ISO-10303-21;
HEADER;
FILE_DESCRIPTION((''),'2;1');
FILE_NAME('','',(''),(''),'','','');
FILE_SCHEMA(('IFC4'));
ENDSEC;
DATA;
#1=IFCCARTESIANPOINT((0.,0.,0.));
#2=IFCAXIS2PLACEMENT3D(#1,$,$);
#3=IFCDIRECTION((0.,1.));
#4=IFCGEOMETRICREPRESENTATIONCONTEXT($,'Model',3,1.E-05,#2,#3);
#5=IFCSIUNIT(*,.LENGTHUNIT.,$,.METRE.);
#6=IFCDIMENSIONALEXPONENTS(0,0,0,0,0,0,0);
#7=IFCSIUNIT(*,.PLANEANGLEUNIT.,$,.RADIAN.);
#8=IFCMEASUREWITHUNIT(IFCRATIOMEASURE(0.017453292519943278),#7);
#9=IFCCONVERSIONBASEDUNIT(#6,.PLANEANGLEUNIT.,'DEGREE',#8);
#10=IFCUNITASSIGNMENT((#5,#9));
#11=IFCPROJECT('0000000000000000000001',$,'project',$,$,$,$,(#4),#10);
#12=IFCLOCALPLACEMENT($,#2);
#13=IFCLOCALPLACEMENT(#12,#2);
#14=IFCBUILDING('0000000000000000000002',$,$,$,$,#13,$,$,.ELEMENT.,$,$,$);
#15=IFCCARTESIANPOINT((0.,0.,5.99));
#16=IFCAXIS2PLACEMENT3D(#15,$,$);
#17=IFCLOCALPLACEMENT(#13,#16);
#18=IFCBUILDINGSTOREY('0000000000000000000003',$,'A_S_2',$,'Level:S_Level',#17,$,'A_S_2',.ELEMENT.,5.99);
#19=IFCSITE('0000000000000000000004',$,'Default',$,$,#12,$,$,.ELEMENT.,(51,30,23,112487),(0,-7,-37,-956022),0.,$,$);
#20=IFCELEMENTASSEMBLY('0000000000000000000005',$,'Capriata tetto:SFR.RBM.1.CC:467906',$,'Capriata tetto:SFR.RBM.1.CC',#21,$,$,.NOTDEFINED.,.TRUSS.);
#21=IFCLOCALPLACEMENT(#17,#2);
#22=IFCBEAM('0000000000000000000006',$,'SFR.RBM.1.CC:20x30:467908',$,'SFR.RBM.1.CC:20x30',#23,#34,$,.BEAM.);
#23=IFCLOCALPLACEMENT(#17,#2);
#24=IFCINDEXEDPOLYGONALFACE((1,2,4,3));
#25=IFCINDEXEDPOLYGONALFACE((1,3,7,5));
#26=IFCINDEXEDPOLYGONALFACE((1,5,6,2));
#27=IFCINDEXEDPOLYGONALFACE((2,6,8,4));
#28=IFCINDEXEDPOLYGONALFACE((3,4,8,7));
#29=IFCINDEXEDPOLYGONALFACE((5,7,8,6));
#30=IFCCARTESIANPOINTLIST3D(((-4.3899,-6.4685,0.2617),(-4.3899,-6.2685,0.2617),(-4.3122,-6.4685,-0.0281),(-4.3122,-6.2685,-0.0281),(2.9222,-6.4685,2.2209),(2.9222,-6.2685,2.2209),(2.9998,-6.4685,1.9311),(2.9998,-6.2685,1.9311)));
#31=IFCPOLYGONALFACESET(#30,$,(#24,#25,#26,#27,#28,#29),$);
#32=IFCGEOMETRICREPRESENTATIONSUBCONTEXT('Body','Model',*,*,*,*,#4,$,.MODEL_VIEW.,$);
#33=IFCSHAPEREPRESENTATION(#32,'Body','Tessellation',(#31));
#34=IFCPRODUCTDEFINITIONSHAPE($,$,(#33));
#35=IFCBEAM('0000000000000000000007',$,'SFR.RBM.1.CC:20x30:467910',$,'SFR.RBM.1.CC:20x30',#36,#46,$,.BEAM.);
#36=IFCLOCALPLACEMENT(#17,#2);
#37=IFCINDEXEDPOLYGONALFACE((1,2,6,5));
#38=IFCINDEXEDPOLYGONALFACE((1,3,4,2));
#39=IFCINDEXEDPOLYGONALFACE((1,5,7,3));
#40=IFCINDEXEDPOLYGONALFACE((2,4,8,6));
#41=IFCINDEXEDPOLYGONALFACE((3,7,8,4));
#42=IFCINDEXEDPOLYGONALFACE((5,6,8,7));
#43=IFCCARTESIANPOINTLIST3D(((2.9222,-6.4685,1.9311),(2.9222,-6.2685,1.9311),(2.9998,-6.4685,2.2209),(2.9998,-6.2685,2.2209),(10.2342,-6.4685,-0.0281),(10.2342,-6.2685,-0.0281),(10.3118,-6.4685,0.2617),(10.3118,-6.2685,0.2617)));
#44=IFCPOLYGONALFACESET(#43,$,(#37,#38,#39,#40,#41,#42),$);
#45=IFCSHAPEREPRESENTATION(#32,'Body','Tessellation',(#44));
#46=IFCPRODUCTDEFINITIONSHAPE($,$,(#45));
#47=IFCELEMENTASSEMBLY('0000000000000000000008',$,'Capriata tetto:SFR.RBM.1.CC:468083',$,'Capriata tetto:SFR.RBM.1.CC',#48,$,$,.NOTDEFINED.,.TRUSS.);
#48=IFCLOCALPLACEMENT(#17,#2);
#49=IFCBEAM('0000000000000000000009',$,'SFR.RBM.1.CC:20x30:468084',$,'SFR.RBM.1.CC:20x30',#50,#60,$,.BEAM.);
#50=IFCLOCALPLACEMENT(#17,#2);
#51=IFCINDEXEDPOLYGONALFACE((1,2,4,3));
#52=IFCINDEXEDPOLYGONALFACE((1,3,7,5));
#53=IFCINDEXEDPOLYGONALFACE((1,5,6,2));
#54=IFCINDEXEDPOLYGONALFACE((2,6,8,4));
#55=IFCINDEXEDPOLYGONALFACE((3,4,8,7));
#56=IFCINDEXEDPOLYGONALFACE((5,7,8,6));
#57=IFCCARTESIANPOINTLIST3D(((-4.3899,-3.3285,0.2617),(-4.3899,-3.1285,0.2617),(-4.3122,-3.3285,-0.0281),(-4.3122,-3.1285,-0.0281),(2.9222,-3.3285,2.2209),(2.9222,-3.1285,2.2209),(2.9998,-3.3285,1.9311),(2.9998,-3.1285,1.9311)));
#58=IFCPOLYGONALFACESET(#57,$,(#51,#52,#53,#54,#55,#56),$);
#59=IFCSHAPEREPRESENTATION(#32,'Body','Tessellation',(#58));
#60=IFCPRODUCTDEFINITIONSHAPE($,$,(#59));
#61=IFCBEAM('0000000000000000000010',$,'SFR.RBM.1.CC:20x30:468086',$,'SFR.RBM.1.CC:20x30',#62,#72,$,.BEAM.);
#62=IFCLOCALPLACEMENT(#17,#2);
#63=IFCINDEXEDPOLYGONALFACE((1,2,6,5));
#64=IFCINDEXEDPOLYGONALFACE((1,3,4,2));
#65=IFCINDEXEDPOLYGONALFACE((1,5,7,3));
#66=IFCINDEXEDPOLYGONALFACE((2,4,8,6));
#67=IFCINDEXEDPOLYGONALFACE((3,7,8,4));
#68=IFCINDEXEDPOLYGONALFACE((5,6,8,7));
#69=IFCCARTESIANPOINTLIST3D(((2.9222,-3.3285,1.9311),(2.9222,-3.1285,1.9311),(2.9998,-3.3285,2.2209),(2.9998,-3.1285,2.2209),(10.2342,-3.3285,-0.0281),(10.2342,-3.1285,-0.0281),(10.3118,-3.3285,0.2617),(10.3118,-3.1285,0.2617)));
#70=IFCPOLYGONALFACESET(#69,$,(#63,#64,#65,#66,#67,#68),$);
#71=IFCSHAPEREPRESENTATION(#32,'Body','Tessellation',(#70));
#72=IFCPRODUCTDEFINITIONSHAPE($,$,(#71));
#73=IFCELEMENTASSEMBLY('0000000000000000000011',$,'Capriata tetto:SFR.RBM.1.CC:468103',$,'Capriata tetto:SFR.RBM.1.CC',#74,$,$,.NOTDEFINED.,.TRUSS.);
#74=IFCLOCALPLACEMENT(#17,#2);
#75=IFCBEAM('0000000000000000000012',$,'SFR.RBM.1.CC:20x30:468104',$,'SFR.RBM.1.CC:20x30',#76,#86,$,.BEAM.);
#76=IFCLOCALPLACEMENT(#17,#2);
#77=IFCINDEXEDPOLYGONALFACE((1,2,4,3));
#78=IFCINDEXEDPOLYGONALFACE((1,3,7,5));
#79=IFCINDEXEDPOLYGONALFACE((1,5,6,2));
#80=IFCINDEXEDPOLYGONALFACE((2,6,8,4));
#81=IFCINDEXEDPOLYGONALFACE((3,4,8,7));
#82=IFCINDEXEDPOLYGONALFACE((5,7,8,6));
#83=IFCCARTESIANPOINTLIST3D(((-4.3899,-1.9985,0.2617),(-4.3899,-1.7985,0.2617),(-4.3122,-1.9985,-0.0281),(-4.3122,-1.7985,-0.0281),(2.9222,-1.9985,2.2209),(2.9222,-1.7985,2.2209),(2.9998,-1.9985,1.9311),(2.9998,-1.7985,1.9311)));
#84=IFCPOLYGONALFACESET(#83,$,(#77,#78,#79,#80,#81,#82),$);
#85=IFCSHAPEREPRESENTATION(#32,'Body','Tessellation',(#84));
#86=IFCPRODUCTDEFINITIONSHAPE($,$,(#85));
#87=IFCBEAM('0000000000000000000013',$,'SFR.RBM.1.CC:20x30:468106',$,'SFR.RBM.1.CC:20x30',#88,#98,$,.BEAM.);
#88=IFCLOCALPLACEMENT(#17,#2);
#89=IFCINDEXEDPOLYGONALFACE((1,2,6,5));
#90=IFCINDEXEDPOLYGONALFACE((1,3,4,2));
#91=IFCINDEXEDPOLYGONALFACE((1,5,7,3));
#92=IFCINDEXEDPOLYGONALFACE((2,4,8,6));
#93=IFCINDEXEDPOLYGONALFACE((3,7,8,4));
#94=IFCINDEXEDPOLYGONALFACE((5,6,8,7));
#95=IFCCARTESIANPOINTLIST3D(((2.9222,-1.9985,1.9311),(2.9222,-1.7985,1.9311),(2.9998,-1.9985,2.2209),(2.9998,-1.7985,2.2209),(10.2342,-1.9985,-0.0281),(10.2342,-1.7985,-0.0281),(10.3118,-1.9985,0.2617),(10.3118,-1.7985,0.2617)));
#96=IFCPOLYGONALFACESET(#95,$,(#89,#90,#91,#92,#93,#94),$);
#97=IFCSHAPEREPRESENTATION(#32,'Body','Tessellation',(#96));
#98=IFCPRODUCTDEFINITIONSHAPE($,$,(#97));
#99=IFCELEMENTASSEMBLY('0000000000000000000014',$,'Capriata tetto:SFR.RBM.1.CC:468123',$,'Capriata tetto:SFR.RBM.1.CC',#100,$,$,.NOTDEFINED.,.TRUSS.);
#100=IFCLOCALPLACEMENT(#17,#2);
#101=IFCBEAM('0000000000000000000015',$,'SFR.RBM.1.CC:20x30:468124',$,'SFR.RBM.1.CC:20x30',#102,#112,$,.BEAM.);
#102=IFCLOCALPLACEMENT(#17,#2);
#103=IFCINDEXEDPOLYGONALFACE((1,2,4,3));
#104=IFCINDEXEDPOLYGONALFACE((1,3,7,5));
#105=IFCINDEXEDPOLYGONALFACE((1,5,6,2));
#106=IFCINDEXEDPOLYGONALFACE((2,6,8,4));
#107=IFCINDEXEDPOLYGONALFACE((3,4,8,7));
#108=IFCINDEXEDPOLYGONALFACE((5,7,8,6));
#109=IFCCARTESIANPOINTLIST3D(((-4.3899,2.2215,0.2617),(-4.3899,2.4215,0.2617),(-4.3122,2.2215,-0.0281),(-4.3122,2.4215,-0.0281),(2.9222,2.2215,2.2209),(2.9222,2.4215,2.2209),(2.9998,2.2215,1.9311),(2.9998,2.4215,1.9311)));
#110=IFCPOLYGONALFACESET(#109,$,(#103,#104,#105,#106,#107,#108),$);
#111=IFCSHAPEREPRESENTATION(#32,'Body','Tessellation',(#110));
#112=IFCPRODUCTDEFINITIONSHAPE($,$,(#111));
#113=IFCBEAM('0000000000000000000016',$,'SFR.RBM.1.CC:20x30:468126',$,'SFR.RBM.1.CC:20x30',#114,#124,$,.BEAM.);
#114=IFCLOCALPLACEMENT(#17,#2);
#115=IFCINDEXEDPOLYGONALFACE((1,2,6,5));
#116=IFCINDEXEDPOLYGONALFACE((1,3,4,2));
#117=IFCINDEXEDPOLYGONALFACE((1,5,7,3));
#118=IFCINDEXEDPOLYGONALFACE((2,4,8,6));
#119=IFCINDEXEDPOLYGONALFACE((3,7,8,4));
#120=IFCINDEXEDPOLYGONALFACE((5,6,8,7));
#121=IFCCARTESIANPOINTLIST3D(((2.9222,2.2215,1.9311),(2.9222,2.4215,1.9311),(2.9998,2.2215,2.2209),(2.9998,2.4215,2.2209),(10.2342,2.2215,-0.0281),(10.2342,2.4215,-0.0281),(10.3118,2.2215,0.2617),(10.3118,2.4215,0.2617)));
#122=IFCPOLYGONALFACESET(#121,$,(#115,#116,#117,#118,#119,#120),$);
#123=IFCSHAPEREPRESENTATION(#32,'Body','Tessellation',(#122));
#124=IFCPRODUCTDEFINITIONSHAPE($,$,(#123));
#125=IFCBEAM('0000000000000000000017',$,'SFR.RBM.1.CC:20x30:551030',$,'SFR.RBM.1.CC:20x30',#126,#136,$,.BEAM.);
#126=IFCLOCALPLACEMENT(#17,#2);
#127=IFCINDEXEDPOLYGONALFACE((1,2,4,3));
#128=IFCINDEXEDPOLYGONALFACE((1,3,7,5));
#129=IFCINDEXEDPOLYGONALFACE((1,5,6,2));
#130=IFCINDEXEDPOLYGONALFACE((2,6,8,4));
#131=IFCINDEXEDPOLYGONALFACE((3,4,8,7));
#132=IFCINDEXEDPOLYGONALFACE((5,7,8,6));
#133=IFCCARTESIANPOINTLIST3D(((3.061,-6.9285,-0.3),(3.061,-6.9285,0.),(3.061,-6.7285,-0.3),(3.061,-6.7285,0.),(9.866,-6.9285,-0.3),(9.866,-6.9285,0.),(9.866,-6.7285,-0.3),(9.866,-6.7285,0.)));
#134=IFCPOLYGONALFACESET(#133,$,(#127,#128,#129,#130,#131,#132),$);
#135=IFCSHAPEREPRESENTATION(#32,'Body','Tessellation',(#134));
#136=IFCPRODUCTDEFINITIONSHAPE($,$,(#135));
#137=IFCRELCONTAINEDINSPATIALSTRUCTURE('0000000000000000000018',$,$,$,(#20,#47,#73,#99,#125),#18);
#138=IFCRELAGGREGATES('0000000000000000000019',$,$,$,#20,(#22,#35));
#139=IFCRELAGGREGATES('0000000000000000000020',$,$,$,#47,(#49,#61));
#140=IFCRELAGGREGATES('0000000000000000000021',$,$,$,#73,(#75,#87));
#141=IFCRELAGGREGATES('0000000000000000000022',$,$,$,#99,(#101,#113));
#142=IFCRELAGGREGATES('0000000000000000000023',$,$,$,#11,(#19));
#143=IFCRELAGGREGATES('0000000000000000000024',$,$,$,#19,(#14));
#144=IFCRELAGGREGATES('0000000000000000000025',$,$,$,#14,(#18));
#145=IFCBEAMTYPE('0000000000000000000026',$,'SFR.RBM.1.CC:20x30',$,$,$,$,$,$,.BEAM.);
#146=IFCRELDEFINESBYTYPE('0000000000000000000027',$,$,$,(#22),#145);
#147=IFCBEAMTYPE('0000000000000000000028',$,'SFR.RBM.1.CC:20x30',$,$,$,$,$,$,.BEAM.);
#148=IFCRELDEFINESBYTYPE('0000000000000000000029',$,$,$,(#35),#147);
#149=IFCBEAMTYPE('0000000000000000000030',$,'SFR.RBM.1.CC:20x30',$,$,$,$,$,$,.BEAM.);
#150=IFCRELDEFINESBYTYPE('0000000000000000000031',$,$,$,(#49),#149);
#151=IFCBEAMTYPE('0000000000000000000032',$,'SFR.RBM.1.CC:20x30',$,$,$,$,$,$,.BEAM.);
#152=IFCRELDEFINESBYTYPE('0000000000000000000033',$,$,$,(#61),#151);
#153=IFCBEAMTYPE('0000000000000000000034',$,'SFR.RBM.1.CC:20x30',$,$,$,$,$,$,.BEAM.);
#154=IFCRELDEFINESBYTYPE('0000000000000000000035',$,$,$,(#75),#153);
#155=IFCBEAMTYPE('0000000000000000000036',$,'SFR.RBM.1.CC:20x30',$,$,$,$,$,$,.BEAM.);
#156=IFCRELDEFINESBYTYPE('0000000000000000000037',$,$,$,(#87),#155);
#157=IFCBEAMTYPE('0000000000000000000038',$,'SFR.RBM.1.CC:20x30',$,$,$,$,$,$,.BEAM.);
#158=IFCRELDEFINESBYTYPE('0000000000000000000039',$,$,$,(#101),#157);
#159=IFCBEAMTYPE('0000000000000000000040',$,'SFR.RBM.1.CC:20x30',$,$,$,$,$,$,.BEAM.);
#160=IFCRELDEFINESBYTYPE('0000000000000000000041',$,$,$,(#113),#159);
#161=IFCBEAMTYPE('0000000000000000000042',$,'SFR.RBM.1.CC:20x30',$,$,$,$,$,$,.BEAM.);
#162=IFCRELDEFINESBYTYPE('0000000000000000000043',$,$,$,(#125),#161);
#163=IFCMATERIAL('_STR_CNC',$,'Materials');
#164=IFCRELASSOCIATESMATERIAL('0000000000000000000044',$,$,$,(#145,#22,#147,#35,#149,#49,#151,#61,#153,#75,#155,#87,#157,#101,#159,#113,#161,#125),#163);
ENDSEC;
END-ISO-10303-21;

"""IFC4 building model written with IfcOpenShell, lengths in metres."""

from ifc_helpers import new_model, entity, si_unit, converted_unit, direction, frame, origin, place, context, subcontext, project, spatial, indexed_curve, outline, extrude, source, transform, mapped, material, type_object, type_shapes, element, aggregate, save


model = new_model("IFC4")

# Units and contexts
model_context = context("Model", 3, precision=1e-05, world=origin(), true_north=direction((0.0, 1.0)))
body_context = subcontext(model_context, "Body", "Model", "MODEL_VIEW")
ifc_project = project(units=[si_unit("LENGTHUNIT", "METRE"), converted_unit("PLANEANGLEUNIT", "DEGREE", entity("IfcRatioMeasure", 0.017453292519943278), si_unit("PLANEANGLEUNIT", "RADIAN"), dimensions=[0, 0, 0, 0, 0, 0, 0])], contexts=[model_context])

# Site, building, storey
site_placement = place(None, origin())
site = spatial("IfcSite", under=ifc_project, at=site_placement, Name="Default", CompositionType="ELEMENT", RefLatitude=(51, 30, 23, 112487), RefLongitude=(0, -7, -37, -956022), RefElevation=0.0)
building_placement = place(site_placement, origin())
building = spatial("IfcBuilding", under=site, at=building_placement, CompositionType="ELEMENT")
storey_placement = place(building_placement, frame((0.0, 0.0, 5.99)))
storey = spatial("IfcBuildingStorey", under=building, at=storey_placement, Name="A_S_2", ObjectType="Level:S_Level", LongName="A_S_2", CompositionType="ELEMENT", Elevation=5.99)

# Shared definitions
ifc_material_1 = material(Name="_STR_CNC", Category="Materials")

# Element assemblies, beams
assembly_1_placement = place(storey_placement, origin())
assembly_1 = element("IfcElementAssembly", 1, at=assembly_1_placement, inside=storey, Name="Capriata tetto:SFR.RBM.1.CC:467906", ObjectType="Capriata tetto:SFR.RBM.1.CC", AssemblyPlace="NOTDEFINED", PredefinedType="TRUSS")
beam_type_1 = type_object("IfcBeamType", Name="SFR.RBM.1.CC:20x30", PredefinedType="BEAM", material=ifc_material_1)
shared_shape_1 = source(origin(), body_context, "Body", "SweptSolid", [
    extrude(outline(indexed_curve([(-0.1, -0.15), (0.1, -0.15), (0.1, 0.15), (-0.1, 0.15), (-0.1, -0.15)], self_intersect=False)), frame((-4.351, -6.3685, 6.1068), z_axis=(0.965926, 0.0, 0.258819), x_axis=(0.0, -1.0, 0.0)), (0.0, 0.0, 1.0), 7.57),
])
type_shapes(beam_type_1, [shared_shape_1])
beam_1_placement = place(assembly_1_placement, frame((0.0, 0.0, -5.99)))
beam_1 = element("IfcBeam", 2, at=beam_1_placement, type_object=beam_type_1, material=ifc_material_1, Name="SFR.RBM.1.CC:20x30:467908", ObjectType="SFR.RBM.1.CC:20x30", PredefinedType="BEAM", context=body_context, shape_type="MappedRepresentation", body=[
    mapped(shared_shape_1, transform((0.0, 0.0, 0.0), scale=1.0)),
])
beam_type_2 = type_object("IfcBeamType", Name="SFR.RBM.1.CC:20x30", PredefinedType="BEAM", material=ifc_material_1)
shared_shape_2 = source(origin(), body_context, "Body", "SweptSolid", [
    extrude(outline(indexed_curve([(-0.1, -0.15), (0.1, -0.15), (0.1, 0.15), (-0.1, 0.15), (-0.1, -0.15)], self_intersect=False)), frame((2.961, -6.3685, 8.066), z_axis=(0.965926, 0.0, -0.258819), x_axis=(0.0, 1.0, 0.0)), (0.0, 0.0, 1.0), 7.57),
])
type_shapes(beam_type_2, [shared_shape_2])
beam_2_placement = place(assembly_1_placement, frame((0.0, 0.0, -5.99)))
beam_2 = element("IfcBeam", 3, at=beam_2_placement, type_object=beam_type_2, material=ifc_material_1, Name="SFR.RBM.1.CC:20x30:467910", ObjectType="SFR.RBM.1.CC:20x30", PredefinedType="BEAM", context=body_context, shape_type="MappedRepresentation", body=[
    mapped(shared_shape_2, transform((0.0, 0.0, 0.0), scale=1.0)),
])
aggregate(assembly_1, [beam_1, beam_2])
assembly_2_placement = place(storey_placement, origin())
assembly_2 = element("IfcElementAssembly", 4, at=assembly_2_placement, inside=storey, Name="Capriata tetto:SFR.RBM.1.CC:468083", ObjectType="Capriata tetto:SFR.RBM.1.CC", AssemblyPlace="NOTDEFINED", PredefinedType="TRUSS")
beam_type_3 = type_object("IfcBeamType", Name="SFR.RBM.1.CC:20x30", PredefinedType="BEAM", material=ifc_material_1)
shared_shape_3 = source(origin(), body_context, "Body", "SweptSolid", [
    extrude(outline(indexed_curve([(-0.1, -0.15), (0.1, -0.15), (0.1, 0.15), (-0.1, 0.15), (-0.1, -0.15)], self_intersect=False)), frame((-4.351, -3.2285, 6.1068), z_axis=(0.965926, 0.0, 0.258819), x_axis=(0.0, -1.0, 0.0)), (0.0, 0.0, 1.0), 7.57),
])
type_shapes(beam_type_3, [shared_shape_3])
beam_3_placement = place(assembly_2_placement, frame((0.0, 0.0, -5.99)))
beam_3 = element("IfcBeam", 5, at=beam_3_placement, type_object=beam_type_3, material=ifc_material_1, Name="SFR.RBM.1.CC:20x30:468084", ObjectType="SFR.RBM.1.CC:20x30", PredefinedType="BEAM", context=body_context, shape_type="MappedRepresentation", body=[
    mapped(shared_shape_3, transform((0.0, 0.0, 0.0), scale=1.0)),
])
beam_type_4 = type_object("IfcBeamType", Name="SFR.RBM.1.CC:20x30", PredefinedType="BEAM", material=ifc_material_1)
shared_shape_4 = source(origin(), body_context, "Body", "SweptSolid", [
    extrude(outline(indexed_curve([(-0.1, -0.15), (0.1, -0.15), (0.1, 0.15), (-0.1, 0.15), (-0.1, -0.15)], self_intersect=False)), frame((2.961, -3.2285, 8.066), z_axis=(0.965926, 0.0, -0.258819), x_axis=(0.0, 1.0, 0.0)), (0.0, 0.0, 1.0), 7.57),
])
type_shapes(beam_type_4, [shared_shape_4])
beam_4_placement = place(assembly_2_placement, frame((0.0, 0.0, -5.99)))
beam_4 = element("IfcBeam", 6, at=beam_4_placement, type_object=beam_type_4, material=ifc_material_1, Name="SFR.RBM.1.CC:20x30:468086", ObjectType="SFR.RBM.1.CC:20x30", PredefinedType="BEAM", context=body_context, shape_type="MappedRepresentation", body=[
    mapped(shared_shape_4, transform((0.0, 0.0, 0.0), scale=1.0)),
])
aggregate(assembly_2, [beam_3, beam_4])
assembly_3_placement = place(storey_placement, origin())
assembly_3 = element("IfcElementAssembly", 7, at=assembly_3_placement, inside=storey, Name="Capriata tetto:SFR.RBM.1.CC:468103", ObjectType="Capriata tetto:SFR.RBM.1.CC", AssemblyPlace="NOTDEFINED", PredefinedType="TRUSS")
beam_type_5 = type_object("IfcBeamType", Name="SFR.RBM.1.CC:20x30", PredefinedType="BEAM", material=ifc_material_1)
shared_shape_5 = source(origin(), body_context, "Body", "SweptSolid", [
    extrude(outline(indexed_curve([(-0.1, -0.15), (0.1, -0.15), (0.1, 0.15), (-0.1, 0.15), (-0.1, -0.15)], self_intersect=False)), frame((-4.351, -1.8985, 6.1068), z_axis=(0.965926, 0.0, 0.258819), x_axis=(0.0, -1.0, 0.0)), (0.0, 0.0, 1.0), 7.57),
])
type_shapes(beam_type_5, [shared_shape_5])
beam_5_placement = place(assembly_3_placement, frame((0.0, 0.0, -5.99)))
beam_5 = element("IfcBeam", 8, at=beam_5_placement, type_object=beam_type_5, material=ifc_material_1, Name="SFR.RBM.1.CC:20x30:468104", ObjectType="SFR.RBM.1.CC:20x30", PredefinedType="BEAM", context=body_context, shape_type="MappedRepresentation", body=[
    mapped(shared_shape_5, transform((0.0, 0.0, 0.0), scale=1.0)),
])
beam_type_6 = type_object("IfcBeamType", Name="SFR.RBM.1.CC:20x30", PredefinedType="BEAM", material=ifc_material_1)
shared_shape_6 = source(origin(), body_context, "Body", "SweptSolid", [
    extrude(outline(indexed_curve([(-0.1, -0.15), (0.1, -0.15), (0.1, 0.15), (-0.1, 0.15), (-0.1, -0.15)], self_intersect=False)), frame((2.961, -1.8985, 8.066), z_axis=(0.965926, 0.0, -0.258819), x_axis=(0.0, 1.0, 0.0)), (0.0, 0.0, 1.0), 7.57),
])
type_shapes(beam_type_6, [shared_shape_6])
beam_6_placement = place(assembly_3_placement, frame((0.0, 0.0, -5.99)))
beam_6 = element("IfcBeam", 9, at=beam_6_placement, type_object=beam_type_6, material=ifc_material_1, Name="SFR.RBM.1.CC:20x30:468106", ObjectType="SFR.RBM.1.CC:20x30", PredefinedType="BEAM", context=body_context, shape_type="MappedRepresentation", body=[
    mapped(shared_shape_6, transform((0.0, 0.0, 0.0), scale=1.0)),
])
aggregate(assembly_3, [beam_5, beam_6])
assembly_4_placement = place(storey_placement, origin())
assembly_4 = element("IfcElementAssembly", 10, at=assembly_4_placement, inside=storey, Name="Capriata tetto:SFR.RBM.1.CC:468123", ObjectType="Capriata tetto:SFR.RBM.1.CC", AssemblyPlace="NOTDEFINED", PredefinedType="TRUSS")
beam_type_7 = type_object("IfcBeamType", Name="SFR.RBM.1.CC:20x30", PredefinedType="BEAM", material=ifc_material_1)
shared_shape_7 = source(origin(), body_context, "Body", "SweptSolid", [
    extrude(outline(indexed_curve([(-0.1, -0.15), (0.1, -0.15), (0.1, 0.15), (-0.1, 0.15), (-0.1, -0.15)], self_intersect=False)), frame((-4.351, 2.3215, 6.1068), z_axis=(0.965926, 0.0, 0.258819), x_axis=(0.0, -1.0, 0.0)), (0.0, 0.0, 1.0), 7.57),
])
type_shapes(beam_type_7, [shared_shape_7])
beam_7_placement = place(assembly_4_placement, frame((0.0, 0.0, -5.99)))
beam_7 = element("IfcBeam", 11, at=beam_7_placement, type_object=beam_type_7, material=ifc_material_1, Name="SFR.RBM.1.CC:20x30:468124", ObjectType="SFR.RBM.1.CC:20x30", PredefinedType="BEAM", context=body_context, shape_type="MappedRepresentation", body=[
    mapped(shared_shape_7, transform((0.0, 0.0, 0.0), scale=1.0)),
])
beam_type_8 = type_object("IfcBeamType", Name="SFR.RBM.1.CC:20x30", PredefinedType="BEAM", material=ifc_material_1)
shared_shape_8 = source(origin(), body_context, "Body", "SweptSolid", [
    extrude(outline(indexed_curve([(-0.1, -0.15), (0.1, -0.15), (0.1, 0.15), (-0.1, 0.15), (-0.1, -0.15)], self_intersect=False)), frame((2.961, 2.3215, 8.066), z_axis=(0.965926, 0.0, -0.258819), x_axis=(0.0, 1.0, 0.0)), (0.0, 0.0, 1.0), 7.57),
])
type_shapes(beam_type_8, [shared_shape_8])
beam_8_placement = place(assembly_4_placement, frame((0.0, 0.0, -5.99)))
beam_8 = element("IfcBeam", 12, at=beam_8_placement, type_object=beam_type_8, material=ifc_material_1, Name="SFR.RBM.1.CC:20x30:468126", ObjectType="SFR.RBM.1.CC:20x30", PredefinedType="BEAM", context=body_context, shape_type="MappedRepresentation", body=[
    mapped(shared_shape_8, transform((0.0, 0.0, 0.0), scale=1.0)),
])
aggregate(assembly_4, [beam_7, beam_8])

# Beam
beam_type_9 = type_object("IfcBeamType", Name="SFR.RBM.1.CC:20x30", PredefinedType="BEAM", material=ifc_material_1)
shared_shape_9 = source(origin(), body_context, "Body", "SweptSolid", [
    extrude(outline(indexed_curve([(-0.15, -0.1), (0.15, -0.1), (0.15, 0.1), (-0.15, 0.1), (-0.15, -0.1)], self_intersect=False)), frame((9.866, -6.8285, 5.84), z_axis=(-1.0, 0.0, 0.0), x_axis=(0.0, 0.0, -1.0)), (0.0, 0.0, 1.0), 6.805),
])
type_shapes(beam_type_9, [shared_shape_9])
beam_9_placement = place(storey_placement, frame((0.0, 0.0, -5.99)))
element("IfcBeam", 13, at=beam_9_placement, inside=storey, type_object=beam_type_9, material=ifc_material_1, Name="SFR.RBM.1.CC:20x30:551030", ObjectType="SFR.RBM.1.CC:20x30", PredefinedType="BEAM", context=body_context, shape_type="MappedRepresentation", body=[
    mapped(shared_shape_9, transform((0.0, 0.0, 0.0), scale=1.0)),
])

save(model, "model.ifc")
